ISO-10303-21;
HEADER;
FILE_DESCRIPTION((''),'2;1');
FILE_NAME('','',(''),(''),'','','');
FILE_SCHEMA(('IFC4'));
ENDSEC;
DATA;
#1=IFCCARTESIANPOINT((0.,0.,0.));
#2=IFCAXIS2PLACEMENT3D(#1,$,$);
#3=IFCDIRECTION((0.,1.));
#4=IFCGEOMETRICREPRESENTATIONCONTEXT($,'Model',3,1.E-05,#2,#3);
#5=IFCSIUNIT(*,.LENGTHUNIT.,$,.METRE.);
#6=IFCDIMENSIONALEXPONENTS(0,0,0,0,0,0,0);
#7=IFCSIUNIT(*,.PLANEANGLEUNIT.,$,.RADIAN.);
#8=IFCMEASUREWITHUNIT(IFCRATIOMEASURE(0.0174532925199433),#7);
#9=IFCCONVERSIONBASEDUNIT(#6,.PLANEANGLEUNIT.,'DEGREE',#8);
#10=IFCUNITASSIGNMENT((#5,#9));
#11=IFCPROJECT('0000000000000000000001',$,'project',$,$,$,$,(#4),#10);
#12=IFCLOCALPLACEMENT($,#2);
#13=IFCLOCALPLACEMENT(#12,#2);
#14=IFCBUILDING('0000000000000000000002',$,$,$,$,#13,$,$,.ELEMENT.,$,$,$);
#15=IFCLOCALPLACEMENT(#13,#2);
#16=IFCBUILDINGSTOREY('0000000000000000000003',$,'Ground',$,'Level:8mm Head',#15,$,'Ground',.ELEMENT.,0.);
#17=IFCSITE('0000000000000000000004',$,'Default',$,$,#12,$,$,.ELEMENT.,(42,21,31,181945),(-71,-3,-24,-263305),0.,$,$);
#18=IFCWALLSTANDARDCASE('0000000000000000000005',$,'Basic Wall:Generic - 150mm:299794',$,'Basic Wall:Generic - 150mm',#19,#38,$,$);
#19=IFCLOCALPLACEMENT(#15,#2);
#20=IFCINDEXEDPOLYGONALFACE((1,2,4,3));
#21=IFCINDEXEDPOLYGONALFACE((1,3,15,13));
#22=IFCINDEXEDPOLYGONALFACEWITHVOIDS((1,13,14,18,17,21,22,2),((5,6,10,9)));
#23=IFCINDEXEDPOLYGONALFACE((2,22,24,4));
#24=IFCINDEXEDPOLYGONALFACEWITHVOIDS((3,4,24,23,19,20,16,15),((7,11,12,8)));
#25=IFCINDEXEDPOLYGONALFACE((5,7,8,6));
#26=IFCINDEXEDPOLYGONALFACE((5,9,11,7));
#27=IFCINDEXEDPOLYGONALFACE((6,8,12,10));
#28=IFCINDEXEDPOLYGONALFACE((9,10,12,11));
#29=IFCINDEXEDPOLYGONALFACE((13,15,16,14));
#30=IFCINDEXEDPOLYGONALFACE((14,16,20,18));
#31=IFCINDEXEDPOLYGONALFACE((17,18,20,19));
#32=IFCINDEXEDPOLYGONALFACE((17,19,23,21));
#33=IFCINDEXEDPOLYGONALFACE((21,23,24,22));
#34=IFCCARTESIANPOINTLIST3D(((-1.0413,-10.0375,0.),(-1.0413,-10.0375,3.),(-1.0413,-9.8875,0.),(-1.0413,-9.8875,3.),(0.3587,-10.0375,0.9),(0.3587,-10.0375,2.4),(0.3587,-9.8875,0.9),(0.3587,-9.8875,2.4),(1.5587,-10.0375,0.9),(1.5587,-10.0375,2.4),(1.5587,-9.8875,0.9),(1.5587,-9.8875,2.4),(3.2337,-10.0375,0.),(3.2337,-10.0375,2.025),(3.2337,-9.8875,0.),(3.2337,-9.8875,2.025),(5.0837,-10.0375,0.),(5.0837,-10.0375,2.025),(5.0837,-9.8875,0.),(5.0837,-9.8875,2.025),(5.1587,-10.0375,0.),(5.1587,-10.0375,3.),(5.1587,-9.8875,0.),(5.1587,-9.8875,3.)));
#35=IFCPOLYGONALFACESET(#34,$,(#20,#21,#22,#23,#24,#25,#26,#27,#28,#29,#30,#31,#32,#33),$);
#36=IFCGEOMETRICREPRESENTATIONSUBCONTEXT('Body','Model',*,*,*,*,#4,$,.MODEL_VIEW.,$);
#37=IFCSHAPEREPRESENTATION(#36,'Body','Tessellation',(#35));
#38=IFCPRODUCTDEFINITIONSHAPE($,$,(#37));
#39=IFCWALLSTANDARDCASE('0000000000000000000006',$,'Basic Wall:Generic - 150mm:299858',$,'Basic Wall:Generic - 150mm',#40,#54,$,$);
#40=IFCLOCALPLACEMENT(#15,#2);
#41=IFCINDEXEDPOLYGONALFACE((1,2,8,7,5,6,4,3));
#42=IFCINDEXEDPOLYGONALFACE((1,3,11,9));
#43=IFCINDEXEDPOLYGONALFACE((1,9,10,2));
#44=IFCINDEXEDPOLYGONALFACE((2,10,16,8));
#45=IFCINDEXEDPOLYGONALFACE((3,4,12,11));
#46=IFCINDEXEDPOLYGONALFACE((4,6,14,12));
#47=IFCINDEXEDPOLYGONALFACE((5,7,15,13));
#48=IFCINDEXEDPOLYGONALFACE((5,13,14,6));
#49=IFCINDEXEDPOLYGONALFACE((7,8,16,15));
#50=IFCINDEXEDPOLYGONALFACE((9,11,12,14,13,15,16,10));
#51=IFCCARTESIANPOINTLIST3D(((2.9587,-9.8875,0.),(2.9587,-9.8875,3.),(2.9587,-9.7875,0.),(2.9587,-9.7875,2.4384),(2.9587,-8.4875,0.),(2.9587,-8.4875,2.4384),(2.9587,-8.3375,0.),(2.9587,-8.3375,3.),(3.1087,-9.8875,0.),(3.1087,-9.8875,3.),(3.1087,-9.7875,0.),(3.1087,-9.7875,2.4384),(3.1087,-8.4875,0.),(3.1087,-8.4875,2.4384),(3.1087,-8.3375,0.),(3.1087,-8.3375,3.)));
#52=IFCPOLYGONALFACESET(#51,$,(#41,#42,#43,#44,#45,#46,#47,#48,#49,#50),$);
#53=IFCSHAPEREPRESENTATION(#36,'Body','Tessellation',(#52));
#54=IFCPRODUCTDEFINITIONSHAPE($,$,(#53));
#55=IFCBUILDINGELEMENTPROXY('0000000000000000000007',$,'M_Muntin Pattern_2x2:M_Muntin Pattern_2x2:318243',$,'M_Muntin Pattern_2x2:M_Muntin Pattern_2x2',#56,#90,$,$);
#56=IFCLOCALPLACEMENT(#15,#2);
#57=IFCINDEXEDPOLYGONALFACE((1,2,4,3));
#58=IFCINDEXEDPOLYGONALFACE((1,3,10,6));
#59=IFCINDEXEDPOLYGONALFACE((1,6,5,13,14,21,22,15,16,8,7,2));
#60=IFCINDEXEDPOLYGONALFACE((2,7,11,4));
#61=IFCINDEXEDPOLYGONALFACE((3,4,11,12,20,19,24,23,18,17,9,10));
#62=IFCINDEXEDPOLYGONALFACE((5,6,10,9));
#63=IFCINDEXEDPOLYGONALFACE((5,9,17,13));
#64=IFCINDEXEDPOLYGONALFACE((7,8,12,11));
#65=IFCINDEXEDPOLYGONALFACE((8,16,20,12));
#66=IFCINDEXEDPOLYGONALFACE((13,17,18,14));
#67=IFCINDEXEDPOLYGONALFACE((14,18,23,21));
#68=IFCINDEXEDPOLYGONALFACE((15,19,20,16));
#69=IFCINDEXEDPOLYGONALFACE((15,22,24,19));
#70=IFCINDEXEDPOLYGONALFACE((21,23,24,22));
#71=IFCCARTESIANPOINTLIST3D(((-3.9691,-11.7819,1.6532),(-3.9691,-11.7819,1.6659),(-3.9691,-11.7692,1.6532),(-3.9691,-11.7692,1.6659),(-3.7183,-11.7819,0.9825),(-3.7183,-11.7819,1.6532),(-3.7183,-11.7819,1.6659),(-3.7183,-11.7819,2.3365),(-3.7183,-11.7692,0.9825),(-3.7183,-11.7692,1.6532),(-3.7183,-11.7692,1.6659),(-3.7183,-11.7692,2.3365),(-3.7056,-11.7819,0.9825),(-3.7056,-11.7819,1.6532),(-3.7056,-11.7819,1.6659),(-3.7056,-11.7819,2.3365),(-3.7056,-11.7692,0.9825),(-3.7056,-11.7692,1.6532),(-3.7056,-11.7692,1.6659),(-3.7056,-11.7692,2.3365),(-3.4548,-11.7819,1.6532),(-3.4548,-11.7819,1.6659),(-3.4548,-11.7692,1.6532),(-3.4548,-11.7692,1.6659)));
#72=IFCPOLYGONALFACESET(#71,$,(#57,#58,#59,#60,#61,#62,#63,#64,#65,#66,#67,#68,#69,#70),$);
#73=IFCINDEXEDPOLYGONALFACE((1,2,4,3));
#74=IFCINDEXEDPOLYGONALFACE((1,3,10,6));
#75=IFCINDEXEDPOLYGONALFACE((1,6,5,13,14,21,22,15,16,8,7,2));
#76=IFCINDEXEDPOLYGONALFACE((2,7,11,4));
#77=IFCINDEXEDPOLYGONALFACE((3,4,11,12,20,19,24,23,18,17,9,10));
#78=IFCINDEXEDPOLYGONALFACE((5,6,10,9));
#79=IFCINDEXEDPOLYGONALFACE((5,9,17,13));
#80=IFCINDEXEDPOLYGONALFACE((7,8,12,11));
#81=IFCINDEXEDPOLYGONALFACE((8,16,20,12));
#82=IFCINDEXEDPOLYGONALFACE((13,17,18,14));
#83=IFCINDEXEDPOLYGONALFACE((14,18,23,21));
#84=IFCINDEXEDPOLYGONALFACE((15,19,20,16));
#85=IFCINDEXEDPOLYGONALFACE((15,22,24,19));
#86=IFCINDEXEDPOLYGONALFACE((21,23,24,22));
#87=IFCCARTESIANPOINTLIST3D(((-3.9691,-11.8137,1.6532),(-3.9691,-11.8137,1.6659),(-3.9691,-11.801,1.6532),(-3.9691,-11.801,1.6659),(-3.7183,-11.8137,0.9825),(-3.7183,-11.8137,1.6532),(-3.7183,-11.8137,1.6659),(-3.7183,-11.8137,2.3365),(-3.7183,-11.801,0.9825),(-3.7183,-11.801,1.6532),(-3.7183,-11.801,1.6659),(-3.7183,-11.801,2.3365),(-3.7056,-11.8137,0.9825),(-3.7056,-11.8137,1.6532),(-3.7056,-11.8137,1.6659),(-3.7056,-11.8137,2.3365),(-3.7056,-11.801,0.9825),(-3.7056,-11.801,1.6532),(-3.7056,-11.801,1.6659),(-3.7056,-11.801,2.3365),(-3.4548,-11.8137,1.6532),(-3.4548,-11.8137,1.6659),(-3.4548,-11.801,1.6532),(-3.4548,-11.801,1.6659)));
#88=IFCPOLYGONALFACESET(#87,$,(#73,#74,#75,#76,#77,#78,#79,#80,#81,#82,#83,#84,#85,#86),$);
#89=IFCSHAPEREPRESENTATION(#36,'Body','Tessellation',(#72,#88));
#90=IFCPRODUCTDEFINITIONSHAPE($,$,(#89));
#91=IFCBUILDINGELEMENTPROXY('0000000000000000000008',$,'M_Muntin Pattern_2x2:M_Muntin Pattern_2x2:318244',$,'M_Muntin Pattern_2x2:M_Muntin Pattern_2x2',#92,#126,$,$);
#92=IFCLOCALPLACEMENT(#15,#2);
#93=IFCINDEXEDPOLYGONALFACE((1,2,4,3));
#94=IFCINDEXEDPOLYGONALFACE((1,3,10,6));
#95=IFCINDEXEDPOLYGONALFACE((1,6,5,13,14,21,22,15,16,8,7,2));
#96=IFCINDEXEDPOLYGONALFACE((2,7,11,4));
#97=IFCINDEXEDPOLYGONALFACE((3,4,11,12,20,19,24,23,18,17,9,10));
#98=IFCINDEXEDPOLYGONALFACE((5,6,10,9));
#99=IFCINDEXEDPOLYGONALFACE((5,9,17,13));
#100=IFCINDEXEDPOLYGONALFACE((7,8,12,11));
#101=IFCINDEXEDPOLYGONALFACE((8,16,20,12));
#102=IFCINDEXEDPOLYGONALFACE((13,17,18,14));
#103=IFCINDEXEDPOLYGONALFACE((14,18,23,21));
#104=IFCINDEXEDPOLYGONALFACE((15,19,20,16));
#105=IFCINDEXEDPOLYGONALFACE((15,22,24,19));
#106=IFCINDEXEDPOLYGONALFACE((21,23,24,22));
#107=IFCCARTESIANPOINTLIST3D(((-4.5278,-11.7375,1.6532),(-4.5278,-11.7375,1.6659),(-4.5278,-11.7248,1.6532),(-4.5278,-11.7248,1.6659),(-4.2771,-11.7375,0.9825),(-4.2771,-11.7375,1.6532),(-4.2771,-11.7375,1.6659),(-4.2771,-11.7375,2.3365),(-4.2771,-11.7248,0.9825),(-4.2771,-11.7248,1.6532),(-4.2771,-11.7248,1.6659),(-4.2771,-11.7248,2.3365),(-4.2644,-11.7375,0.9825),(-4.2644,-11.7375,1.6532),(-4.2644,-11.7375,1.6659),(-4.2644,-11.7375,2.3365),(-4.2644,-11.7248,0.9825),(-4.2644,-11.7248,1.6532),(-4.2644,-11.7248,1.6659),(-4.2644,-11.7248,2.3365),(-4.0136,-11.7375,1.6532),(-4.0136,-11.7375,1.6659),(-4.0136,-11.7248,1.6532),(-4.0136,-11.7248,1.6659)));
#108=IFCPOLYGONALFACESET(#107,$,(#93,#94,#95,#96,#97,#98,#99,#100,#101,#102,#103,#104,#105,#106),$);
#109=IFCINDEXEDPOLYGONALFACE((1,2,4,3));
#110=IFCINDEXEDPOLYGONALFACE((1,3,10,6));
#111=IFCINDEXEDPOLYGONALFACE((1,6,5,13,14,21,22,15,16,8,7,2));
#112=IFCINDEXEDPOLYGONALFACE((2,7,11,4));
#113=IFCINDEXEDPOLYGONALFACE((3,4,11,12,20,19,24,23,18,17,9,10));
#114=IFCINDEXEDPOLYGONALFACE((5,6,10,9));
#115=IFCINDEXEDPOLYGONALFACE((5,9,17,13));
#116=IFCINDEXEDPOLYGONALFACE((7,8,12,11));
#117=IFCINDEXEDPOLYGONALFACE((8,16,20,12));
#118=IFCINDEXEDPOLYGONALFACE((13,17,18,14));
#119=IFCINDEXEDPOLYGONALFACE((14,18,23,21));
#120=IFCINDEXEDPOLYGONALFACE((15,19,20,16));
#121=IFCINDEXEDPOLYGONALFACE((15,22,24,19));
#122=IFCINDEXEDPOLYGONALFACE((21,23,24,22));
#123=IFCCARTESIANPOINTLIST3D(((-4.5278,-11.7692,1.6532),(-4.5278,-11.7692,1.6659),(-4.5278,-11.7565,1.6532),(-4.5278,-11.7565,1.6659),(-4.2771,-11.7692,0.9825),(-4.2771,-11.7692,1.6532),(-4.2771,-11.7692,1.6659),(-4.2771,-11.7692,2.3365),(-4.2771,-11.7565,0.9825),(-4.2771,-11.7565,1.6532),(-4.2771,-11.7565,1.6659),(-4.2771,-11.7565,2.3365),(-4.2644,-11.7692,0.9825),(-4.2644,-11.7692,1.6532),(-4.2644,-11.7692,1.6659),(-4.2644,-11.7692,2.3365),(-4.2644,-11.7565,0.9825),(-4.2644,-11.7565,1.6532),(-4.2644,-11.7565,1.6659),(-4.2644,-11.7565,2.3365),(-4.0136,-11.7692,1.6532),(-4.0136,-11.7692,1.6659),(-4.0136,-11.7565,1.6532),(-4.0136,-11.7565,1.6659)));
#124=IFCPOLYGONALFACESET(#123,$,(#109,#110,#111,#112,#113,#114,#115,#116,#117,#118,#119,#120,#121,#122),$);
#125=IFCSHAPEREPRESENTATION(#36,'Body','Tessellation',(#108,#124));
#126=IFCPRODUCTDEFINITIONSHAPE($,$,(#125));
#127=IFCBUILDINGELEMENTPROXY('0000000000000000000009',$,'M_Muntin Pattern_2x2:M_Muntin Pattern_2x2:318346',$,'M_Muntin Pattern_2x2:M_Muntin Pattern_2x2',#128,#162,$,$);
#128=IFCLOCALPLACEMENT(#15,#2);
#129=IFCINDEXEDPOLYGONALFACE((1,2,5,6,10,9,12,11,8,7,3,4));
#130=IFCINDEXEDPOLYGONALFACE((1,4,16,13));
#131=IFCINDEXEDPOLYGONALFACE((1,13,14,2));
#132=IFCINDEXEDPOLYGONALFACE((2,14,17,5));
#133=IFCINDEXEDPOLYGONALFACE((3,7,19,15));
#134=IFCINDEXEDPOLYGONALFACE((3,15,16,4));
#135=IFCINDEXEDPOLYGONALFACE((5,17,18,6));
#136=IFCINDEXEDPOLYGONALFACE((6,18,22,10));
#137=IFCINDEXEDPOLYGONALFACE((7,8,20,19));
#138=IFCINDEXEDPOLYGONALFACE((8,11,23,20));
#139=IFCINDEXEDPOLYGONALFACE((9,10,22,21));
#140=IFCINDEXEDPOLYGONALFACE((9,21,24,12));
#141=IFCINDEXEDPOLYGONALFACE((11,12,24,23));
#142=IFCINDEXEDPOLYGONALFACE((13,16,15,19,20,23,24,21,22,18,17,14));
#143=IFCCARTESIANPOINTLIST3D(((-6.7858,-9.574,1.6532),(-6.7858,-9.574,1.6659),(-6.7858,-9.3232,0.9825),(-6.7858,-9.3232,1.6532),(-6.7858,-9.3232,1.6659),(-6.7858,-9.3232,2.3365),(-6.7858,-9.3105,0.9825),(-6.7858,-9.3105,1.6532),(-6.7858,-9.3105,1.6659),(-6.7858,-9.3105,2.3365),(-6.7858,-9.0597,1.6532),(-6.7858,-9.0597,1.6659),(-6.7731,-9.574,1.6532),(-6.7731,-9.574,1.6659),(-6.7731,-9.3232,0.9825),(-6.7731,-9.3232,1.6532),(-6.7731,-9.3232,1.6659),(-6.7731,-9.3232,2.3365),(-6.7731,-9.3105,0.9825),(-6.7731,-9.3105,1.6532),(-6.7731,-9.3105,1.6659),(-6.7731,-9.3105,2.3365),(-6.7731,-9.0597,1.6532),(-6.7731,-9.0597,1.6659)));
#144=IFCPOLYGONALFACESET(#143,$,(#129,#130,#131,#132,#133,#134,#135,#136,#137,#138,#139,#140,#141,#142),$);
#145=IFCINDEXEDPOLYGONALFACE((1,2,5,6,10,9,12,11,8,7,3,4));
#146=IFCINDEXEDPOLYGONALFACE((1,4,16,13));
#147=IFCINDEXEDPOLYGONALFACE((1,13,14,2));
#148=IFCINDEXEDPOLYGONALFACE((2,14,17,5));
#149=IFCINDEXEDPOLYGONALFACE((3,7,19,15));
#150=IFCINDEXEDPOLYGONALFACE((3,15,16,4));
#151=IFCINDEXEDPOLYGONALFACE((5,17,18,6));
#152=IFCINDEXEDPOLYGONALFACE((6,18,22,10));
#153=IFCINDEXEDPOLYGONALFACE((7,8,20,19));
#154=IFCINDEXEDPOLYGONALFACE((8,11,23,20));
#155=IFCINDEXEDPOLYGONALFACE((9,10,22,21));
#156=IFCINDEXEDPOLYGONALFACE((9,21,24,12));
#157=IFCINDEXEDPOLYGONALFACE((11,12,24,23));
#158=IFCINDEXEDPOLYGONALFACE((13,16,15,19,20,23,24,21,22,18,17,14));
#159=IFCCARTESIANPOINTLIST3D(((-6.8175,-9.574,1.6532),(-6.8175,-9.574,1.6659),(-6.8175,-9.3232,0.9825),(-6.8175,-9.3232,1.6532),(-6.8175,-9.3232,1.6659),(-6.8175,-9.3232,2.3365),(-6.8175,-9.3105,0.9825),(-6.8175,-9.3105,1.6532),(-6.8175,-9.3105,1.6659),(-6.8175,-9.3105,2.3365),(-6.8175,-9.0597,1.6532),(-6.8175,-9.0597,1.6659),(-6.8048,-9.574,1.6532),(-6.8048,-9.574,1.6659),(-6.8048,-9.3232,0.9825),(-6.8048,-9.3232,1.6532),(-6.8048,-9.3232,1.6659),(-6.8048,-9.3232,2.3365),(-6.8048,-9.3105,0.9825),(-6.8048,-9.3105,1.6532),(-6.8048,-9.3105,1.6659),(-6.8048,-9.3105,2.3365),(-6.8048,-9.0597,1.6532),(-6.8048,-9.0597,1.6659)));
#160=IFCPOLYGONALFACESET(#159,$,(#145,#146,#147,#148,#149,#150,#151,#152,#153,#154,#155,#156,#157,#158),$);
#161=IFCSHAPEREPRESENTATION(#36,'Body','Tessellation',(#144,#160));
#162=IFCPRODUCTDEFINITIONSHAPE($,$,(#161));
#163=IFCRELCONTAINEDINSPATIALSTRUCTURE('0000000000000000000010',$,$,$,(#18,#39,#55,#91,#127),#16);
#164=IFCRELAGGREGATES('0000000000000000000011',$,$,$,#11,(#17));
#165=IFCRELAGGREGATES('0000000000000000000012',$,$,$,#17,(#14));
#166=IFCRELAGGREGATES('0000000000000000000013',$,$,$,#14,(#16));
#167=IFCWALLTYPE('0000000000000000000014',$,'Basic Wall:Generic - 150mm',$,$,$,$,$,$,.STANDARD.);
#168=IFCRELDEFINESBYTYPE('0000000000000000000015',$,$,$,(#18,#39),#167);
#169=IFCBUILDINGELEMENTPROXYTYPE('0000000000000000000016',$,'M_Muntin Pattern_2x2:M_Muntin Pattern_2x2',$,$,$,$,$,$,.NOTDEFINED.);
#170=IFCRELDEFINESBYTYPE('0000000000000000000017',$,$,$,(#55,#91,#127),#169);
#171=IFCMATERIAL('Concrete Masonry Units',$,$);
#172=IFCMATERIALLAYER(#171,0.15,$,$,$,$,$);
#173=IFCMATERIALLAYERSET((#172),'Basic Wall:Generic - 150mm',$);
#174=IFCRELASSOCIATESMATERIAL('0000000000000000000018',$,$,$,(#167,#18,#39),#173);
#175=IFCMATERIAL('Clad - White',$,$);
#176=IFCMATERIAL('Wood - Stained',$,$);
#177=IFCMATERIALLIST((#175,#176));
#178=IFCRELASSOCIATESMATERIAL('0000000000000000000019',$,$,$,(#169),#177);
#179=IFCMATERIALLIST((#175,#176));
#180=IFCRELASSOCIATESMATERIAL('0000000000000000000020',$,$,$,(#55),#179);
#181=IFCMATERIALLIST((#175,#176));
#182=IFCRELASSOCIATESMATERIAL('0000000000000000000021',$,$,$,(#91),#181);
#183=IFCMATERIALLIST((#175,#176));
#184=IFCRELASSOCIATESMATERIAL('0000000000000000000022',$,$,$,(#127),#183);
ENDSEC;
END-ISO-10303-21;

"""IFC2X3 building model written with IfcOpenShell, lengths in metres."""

from ifc_helpers import new_model, entity, si_unit, converted_unit, direction, frame, frame_2d, origin, place, context, subcontext, project, spatial, polyline, rectangle, outline, extrude, source, transform, mapped, material, material_list, layer, layer_set, layer_usage, type_object, type_shapes, element, save


model = new_model("IFC2X3")

# Units and contexts
model_context = context("Model", 3, precision=1e-05, world=origin(), true_north=direction((0.0, 1.0)))
body_context = subcontext(model_context, "Body", "Model", "MODEL_VIEW")
ifc_project = project(units=[si_unit("LENGTHUNIT", "METRE"), converted_unit("PLANEANGLEUNIT", "DEGREE", entity("IfcRatioMeasure", 0.0174532925199433), si_unit("PLANEANGLEUNIT", "RADIAN"), dimensions=[0, 0, 0, 0, 0, 0, 0])], contexts=[model_context])

# Site, building, storey
site_placement = place(None, origin())
site = spatial("IfcSite", under=ifc_project, at=site_placement, Name="Default", CompositionType="ELEMENT", RefLatitude=(42, 21, 31, 181945), RefLongitude=(-71, -3, -24, -263305), RefElevation=0.0)
building_placement = place(site_placement, origin())
building = spatial("IfcBuilding", under=site, at=building_placement, CompositionType="ELEMENT")
storey_placement = place(building_placement, origin())
storey = spatial("IfcBuildingStorey", under=building, at=storey_placement, Name="Ground", ObjectType="Level:8mm Head", LongName="Ground", CompositionType="ELEMENT", Elevation=0.0)

# Shared definitions
ifc_material_1 = material(Name="Concrete Masonry Units")
ifc_layer = layer(ifc_material_1, 0.15)
ifc_layer_set = layer_set([ifc_layer], Name="Basic Wall:Generic - 150mm")
wall_type = type_object("IfcWallType", Name="Basic Wall:Generic - 150mm", PredefinedType="STANDARD", material=ifc_layer_set)

# Wall, openings
ifc_layer_usage_1 = layer_usage(ifc_layer_set, "AXIS2", "NEGATIVE", 0.075)
wall_1_placement = place(storey_placement, frame((-1.0413, -9.9625, 0.0)))
wall_1 = element("IfcWallStandardCase", 1, at=wall_1_placement, inside=storey, type_object=wall_type, material=ifc_layer_usage_1, Name="Basic Wall:Generic - 150mm:299794", ObjectType="Basic Wall:Generic - 150mm", context=body_context, shape_type="SweptSolid", body=[
    extrude(rectangle(XDim=6.2, YDim=0.15, at=frame_2d((3.1, 0.0), x_axis=(-1.0, 0.0))), origin(), (0.0, 0.0, 1.0), 3.0),
])
opening_1_placement = place(wall_1_placement, frame((4.275, -0.075, 0.0)))
element("IfcOpeningElement", 2, at=opening_1_placement, cuts=wall_1, ObjectType="Opening", context=body_context, shape_type="SweptSolid", body=[
    extrude(rectangle(XDim=2.025, YDim=1.85, at=frame_2d((1.0125, 0.925), x_axis=(1.0, 0.0))), frame((0.0, 0.0, 0.0), z_axis=(0.0, 1.0, 0.0), x_axis=(0.0, 0.0, 1.0)), (0.0, 0.0, 1.0), 0.15),
])
opening_2_placement = place(wall_1_placement, frame((1.4, -0.075, 0.9)))
element("IfcOpeningElement", 3, at=opening_2_placement, cuts=wall_1, ObjectType="Opening", context=body_context, shape_type="SweptSolid", body=[
    extrude(rectangle(XDim=1.5, YDim=1.2, at=frame_2d((0.75, 0.6), x_axis=(-1.0, 0.0))), frame((0.0, 0.0, 0.0), z_axis=(0.0, 1.0, 0.0), x_axis=(0.0, 0.0, 1.0)), (0.0, 0.0, 1.0), 0.15),
])

# Wall, opening
ifc_layer_usage_2 = layer_usage(ifc_layer_set, "AXIS2", "NEGATIVE", 0.075)
wall_2_placement = place(storey_placement, frame((3.0337, -9.8875, 0.0), z_axis=(0.0, 0.0, 1.0), x_axis=(0.0, 1.0, 0.0)))
wall_2 = element("IfcWallStandardCase", 4, at=wall_2_placement, inside=storey, type_object=wall_type, material=ifc_layer_usage_2, Name="Basic Wall:Generic - 150mm:299858", ObjectType="Basic Wall:Generic - 150mm", context=body_context, shape_type="SweptSolid", body=[
    extrude(rectangle(XDim=1.55, YDim=0.15, at=frame_2d((0.775, 0.0), x_axis=(-1.0, 0.0))), origin(), (0.0, 0.0, 1.0), 3.0),
])
opening_3_placement = place(wall_2_placement, origin())
element("IfcOpeningElement", 5, at=opening_3_placement, cuts=wall_2, ObjectType="Opening", context=body_context, shape_type="SweptSolid", body=[
    extrude(rectangle(XDim=2.4384, YDim=1.3, at=frame_2d((0.0, 0.0), x_axis=(1.0, 0.0))), frame((0.75, -0.075, 1.2192), z_axis=(0.0, 1.0, 0.0), x_axis=(0.0, 0.0, -1.0)), (0.0, 0.0, 1.0), 0.15),
])

# Building element proxies
ifc_material_2 = material(Name="Clad - White")
ifc_material_3 = material(Name="Wood - Stained")
ifc_material_list_1 = material_list([ifc_material_2, ifc_material_3])
ifc_material_list_2 = material_list([ifc_material_2, ifc_material_3])
building_element_proxy_type_1 = type_object("IfcBuildingElementProxyType", Name="M_Muntin Pattern_2x2:M_Muntin Pattern_2x2", PredefinedType="NOTDEFINED", material=ifc_material_list_2)
shared_shape_1 = source(origin(), body_context, "Body", "SweptSolid", [
    extrude(outline(polyline([(0.0064, -0.0064), (0.677, -0.0064), (0.677, 0.0063), (0.0064, 0.0063), (0.0064, 0.2571), (-0.0063, 0.2571), (-0.0063, 0.0063), (-0.677, 0.0063), (-0.677, -0.0064), (-0.0063, -0.0064), (-0.0063, -0.2571), (0.0064, -0.2571), (0.0064, -0.0064)])), frame((0.0, 0.0095, 0.677), z_axis=(0.0, 1.0, 0.0), x_axis=(0.0, 0.0, 1.0)), (0.0, 0.0, 1.0), 0.0127),
    extrude(outline(polyline([(0.0064, -0.0064), (0.677, -0.0064), (0.677, 0.0063), (0.0064, 0.0063), (0.0064, 0.2571), (-0.0063, 0.2571), (-0.0063, 0.0063), (-0.677, 0.0063), (-0.677, -0.0064), (-0.0063, -0.0064), (-0.0063, -0.2571), (0.0064, -0.2571), (0.0064, -0.0064)])), frame((0.0, -0.0222, 0.677), z_axis=(0.0, 1.0, 0.0), x_axis=(0.0, 0.0, 1.0)), (0.0, 0.0, 1.0), 0.0127),
])
type_shapes(building_element_proxy_type_1, [shared_shape_1])
proxy_1_placement = place(storey_placement, frame((-3.712, -11.7914, 0.9825)))
element("IfcBuildingElementProxy", 6, at=proxy_1_placement, inside=storey, type_object=building_element_proxy_type_1, material=ifc_material_list_1, Name="M_Muntin Pattern_2x2:M_Muntin Pattern_2x2:318243", ObjectType="M_Muntin Pattern_2x2:M_Muntin Pattern_2x2", context=body_context, shape_type="MappedRepresentation", body=[
    mapped(shared_shape_1, transform((0.0, 0.0, 0.0), scale=1.0)),
])
ifc_material_list_3 = material_list([ifc_material_2, ifc_material_3])
proxy_2_placement = place(storey_placement, frame((-4.2707, -11.747, 0.9825)))
element("IfcBuildingElementProxy", 7, at=proxy_2_placement, inside=storey, type_object=building_element_proxy_type_1, material=ifc_material_list_3, Name="M_Muntin Pattern_2x2:M_Muntin Pattern_2x2:318244", ObjectType="M_Muntin Pattern_2x2:M_Muntin Pattern_2x2", context=body_context, shape_type="MappedRepresentation", body=[
    mapped(shared_shape_1, transform((0.0, 0.0, 0.0), scale=1.0)),
])
ifc_material_list_4 = material_list([ifc_material_2, ifc_material_3])
proxy_3_placement = place(storey_placement, frame((-6.7953, -9.3168, 0.9825), z_axis=(0.0, 0.0, 1.0), x_axis=(0.0, -1.0, 0.0)))
element("IfcBuildingElementProxy", 8, at=proxy_3_placement, inside=storey, type_object=building_element_proxy_type_1, material=ifc_material_list_4, Name="M_Muntin Pattern_2x2:M_Muntin Pattern_2x2:318346", ObjectType="M_Muntin Pattern_2x2:M_Muntin Pattern_2x2", context=body_context, shape_type="MappedRepresentation", body=[
    mapped(shared_shape_1, transform((0.0, 0.0, 0.0), scale=1.0)),
])

save(model, "model.ifc")
